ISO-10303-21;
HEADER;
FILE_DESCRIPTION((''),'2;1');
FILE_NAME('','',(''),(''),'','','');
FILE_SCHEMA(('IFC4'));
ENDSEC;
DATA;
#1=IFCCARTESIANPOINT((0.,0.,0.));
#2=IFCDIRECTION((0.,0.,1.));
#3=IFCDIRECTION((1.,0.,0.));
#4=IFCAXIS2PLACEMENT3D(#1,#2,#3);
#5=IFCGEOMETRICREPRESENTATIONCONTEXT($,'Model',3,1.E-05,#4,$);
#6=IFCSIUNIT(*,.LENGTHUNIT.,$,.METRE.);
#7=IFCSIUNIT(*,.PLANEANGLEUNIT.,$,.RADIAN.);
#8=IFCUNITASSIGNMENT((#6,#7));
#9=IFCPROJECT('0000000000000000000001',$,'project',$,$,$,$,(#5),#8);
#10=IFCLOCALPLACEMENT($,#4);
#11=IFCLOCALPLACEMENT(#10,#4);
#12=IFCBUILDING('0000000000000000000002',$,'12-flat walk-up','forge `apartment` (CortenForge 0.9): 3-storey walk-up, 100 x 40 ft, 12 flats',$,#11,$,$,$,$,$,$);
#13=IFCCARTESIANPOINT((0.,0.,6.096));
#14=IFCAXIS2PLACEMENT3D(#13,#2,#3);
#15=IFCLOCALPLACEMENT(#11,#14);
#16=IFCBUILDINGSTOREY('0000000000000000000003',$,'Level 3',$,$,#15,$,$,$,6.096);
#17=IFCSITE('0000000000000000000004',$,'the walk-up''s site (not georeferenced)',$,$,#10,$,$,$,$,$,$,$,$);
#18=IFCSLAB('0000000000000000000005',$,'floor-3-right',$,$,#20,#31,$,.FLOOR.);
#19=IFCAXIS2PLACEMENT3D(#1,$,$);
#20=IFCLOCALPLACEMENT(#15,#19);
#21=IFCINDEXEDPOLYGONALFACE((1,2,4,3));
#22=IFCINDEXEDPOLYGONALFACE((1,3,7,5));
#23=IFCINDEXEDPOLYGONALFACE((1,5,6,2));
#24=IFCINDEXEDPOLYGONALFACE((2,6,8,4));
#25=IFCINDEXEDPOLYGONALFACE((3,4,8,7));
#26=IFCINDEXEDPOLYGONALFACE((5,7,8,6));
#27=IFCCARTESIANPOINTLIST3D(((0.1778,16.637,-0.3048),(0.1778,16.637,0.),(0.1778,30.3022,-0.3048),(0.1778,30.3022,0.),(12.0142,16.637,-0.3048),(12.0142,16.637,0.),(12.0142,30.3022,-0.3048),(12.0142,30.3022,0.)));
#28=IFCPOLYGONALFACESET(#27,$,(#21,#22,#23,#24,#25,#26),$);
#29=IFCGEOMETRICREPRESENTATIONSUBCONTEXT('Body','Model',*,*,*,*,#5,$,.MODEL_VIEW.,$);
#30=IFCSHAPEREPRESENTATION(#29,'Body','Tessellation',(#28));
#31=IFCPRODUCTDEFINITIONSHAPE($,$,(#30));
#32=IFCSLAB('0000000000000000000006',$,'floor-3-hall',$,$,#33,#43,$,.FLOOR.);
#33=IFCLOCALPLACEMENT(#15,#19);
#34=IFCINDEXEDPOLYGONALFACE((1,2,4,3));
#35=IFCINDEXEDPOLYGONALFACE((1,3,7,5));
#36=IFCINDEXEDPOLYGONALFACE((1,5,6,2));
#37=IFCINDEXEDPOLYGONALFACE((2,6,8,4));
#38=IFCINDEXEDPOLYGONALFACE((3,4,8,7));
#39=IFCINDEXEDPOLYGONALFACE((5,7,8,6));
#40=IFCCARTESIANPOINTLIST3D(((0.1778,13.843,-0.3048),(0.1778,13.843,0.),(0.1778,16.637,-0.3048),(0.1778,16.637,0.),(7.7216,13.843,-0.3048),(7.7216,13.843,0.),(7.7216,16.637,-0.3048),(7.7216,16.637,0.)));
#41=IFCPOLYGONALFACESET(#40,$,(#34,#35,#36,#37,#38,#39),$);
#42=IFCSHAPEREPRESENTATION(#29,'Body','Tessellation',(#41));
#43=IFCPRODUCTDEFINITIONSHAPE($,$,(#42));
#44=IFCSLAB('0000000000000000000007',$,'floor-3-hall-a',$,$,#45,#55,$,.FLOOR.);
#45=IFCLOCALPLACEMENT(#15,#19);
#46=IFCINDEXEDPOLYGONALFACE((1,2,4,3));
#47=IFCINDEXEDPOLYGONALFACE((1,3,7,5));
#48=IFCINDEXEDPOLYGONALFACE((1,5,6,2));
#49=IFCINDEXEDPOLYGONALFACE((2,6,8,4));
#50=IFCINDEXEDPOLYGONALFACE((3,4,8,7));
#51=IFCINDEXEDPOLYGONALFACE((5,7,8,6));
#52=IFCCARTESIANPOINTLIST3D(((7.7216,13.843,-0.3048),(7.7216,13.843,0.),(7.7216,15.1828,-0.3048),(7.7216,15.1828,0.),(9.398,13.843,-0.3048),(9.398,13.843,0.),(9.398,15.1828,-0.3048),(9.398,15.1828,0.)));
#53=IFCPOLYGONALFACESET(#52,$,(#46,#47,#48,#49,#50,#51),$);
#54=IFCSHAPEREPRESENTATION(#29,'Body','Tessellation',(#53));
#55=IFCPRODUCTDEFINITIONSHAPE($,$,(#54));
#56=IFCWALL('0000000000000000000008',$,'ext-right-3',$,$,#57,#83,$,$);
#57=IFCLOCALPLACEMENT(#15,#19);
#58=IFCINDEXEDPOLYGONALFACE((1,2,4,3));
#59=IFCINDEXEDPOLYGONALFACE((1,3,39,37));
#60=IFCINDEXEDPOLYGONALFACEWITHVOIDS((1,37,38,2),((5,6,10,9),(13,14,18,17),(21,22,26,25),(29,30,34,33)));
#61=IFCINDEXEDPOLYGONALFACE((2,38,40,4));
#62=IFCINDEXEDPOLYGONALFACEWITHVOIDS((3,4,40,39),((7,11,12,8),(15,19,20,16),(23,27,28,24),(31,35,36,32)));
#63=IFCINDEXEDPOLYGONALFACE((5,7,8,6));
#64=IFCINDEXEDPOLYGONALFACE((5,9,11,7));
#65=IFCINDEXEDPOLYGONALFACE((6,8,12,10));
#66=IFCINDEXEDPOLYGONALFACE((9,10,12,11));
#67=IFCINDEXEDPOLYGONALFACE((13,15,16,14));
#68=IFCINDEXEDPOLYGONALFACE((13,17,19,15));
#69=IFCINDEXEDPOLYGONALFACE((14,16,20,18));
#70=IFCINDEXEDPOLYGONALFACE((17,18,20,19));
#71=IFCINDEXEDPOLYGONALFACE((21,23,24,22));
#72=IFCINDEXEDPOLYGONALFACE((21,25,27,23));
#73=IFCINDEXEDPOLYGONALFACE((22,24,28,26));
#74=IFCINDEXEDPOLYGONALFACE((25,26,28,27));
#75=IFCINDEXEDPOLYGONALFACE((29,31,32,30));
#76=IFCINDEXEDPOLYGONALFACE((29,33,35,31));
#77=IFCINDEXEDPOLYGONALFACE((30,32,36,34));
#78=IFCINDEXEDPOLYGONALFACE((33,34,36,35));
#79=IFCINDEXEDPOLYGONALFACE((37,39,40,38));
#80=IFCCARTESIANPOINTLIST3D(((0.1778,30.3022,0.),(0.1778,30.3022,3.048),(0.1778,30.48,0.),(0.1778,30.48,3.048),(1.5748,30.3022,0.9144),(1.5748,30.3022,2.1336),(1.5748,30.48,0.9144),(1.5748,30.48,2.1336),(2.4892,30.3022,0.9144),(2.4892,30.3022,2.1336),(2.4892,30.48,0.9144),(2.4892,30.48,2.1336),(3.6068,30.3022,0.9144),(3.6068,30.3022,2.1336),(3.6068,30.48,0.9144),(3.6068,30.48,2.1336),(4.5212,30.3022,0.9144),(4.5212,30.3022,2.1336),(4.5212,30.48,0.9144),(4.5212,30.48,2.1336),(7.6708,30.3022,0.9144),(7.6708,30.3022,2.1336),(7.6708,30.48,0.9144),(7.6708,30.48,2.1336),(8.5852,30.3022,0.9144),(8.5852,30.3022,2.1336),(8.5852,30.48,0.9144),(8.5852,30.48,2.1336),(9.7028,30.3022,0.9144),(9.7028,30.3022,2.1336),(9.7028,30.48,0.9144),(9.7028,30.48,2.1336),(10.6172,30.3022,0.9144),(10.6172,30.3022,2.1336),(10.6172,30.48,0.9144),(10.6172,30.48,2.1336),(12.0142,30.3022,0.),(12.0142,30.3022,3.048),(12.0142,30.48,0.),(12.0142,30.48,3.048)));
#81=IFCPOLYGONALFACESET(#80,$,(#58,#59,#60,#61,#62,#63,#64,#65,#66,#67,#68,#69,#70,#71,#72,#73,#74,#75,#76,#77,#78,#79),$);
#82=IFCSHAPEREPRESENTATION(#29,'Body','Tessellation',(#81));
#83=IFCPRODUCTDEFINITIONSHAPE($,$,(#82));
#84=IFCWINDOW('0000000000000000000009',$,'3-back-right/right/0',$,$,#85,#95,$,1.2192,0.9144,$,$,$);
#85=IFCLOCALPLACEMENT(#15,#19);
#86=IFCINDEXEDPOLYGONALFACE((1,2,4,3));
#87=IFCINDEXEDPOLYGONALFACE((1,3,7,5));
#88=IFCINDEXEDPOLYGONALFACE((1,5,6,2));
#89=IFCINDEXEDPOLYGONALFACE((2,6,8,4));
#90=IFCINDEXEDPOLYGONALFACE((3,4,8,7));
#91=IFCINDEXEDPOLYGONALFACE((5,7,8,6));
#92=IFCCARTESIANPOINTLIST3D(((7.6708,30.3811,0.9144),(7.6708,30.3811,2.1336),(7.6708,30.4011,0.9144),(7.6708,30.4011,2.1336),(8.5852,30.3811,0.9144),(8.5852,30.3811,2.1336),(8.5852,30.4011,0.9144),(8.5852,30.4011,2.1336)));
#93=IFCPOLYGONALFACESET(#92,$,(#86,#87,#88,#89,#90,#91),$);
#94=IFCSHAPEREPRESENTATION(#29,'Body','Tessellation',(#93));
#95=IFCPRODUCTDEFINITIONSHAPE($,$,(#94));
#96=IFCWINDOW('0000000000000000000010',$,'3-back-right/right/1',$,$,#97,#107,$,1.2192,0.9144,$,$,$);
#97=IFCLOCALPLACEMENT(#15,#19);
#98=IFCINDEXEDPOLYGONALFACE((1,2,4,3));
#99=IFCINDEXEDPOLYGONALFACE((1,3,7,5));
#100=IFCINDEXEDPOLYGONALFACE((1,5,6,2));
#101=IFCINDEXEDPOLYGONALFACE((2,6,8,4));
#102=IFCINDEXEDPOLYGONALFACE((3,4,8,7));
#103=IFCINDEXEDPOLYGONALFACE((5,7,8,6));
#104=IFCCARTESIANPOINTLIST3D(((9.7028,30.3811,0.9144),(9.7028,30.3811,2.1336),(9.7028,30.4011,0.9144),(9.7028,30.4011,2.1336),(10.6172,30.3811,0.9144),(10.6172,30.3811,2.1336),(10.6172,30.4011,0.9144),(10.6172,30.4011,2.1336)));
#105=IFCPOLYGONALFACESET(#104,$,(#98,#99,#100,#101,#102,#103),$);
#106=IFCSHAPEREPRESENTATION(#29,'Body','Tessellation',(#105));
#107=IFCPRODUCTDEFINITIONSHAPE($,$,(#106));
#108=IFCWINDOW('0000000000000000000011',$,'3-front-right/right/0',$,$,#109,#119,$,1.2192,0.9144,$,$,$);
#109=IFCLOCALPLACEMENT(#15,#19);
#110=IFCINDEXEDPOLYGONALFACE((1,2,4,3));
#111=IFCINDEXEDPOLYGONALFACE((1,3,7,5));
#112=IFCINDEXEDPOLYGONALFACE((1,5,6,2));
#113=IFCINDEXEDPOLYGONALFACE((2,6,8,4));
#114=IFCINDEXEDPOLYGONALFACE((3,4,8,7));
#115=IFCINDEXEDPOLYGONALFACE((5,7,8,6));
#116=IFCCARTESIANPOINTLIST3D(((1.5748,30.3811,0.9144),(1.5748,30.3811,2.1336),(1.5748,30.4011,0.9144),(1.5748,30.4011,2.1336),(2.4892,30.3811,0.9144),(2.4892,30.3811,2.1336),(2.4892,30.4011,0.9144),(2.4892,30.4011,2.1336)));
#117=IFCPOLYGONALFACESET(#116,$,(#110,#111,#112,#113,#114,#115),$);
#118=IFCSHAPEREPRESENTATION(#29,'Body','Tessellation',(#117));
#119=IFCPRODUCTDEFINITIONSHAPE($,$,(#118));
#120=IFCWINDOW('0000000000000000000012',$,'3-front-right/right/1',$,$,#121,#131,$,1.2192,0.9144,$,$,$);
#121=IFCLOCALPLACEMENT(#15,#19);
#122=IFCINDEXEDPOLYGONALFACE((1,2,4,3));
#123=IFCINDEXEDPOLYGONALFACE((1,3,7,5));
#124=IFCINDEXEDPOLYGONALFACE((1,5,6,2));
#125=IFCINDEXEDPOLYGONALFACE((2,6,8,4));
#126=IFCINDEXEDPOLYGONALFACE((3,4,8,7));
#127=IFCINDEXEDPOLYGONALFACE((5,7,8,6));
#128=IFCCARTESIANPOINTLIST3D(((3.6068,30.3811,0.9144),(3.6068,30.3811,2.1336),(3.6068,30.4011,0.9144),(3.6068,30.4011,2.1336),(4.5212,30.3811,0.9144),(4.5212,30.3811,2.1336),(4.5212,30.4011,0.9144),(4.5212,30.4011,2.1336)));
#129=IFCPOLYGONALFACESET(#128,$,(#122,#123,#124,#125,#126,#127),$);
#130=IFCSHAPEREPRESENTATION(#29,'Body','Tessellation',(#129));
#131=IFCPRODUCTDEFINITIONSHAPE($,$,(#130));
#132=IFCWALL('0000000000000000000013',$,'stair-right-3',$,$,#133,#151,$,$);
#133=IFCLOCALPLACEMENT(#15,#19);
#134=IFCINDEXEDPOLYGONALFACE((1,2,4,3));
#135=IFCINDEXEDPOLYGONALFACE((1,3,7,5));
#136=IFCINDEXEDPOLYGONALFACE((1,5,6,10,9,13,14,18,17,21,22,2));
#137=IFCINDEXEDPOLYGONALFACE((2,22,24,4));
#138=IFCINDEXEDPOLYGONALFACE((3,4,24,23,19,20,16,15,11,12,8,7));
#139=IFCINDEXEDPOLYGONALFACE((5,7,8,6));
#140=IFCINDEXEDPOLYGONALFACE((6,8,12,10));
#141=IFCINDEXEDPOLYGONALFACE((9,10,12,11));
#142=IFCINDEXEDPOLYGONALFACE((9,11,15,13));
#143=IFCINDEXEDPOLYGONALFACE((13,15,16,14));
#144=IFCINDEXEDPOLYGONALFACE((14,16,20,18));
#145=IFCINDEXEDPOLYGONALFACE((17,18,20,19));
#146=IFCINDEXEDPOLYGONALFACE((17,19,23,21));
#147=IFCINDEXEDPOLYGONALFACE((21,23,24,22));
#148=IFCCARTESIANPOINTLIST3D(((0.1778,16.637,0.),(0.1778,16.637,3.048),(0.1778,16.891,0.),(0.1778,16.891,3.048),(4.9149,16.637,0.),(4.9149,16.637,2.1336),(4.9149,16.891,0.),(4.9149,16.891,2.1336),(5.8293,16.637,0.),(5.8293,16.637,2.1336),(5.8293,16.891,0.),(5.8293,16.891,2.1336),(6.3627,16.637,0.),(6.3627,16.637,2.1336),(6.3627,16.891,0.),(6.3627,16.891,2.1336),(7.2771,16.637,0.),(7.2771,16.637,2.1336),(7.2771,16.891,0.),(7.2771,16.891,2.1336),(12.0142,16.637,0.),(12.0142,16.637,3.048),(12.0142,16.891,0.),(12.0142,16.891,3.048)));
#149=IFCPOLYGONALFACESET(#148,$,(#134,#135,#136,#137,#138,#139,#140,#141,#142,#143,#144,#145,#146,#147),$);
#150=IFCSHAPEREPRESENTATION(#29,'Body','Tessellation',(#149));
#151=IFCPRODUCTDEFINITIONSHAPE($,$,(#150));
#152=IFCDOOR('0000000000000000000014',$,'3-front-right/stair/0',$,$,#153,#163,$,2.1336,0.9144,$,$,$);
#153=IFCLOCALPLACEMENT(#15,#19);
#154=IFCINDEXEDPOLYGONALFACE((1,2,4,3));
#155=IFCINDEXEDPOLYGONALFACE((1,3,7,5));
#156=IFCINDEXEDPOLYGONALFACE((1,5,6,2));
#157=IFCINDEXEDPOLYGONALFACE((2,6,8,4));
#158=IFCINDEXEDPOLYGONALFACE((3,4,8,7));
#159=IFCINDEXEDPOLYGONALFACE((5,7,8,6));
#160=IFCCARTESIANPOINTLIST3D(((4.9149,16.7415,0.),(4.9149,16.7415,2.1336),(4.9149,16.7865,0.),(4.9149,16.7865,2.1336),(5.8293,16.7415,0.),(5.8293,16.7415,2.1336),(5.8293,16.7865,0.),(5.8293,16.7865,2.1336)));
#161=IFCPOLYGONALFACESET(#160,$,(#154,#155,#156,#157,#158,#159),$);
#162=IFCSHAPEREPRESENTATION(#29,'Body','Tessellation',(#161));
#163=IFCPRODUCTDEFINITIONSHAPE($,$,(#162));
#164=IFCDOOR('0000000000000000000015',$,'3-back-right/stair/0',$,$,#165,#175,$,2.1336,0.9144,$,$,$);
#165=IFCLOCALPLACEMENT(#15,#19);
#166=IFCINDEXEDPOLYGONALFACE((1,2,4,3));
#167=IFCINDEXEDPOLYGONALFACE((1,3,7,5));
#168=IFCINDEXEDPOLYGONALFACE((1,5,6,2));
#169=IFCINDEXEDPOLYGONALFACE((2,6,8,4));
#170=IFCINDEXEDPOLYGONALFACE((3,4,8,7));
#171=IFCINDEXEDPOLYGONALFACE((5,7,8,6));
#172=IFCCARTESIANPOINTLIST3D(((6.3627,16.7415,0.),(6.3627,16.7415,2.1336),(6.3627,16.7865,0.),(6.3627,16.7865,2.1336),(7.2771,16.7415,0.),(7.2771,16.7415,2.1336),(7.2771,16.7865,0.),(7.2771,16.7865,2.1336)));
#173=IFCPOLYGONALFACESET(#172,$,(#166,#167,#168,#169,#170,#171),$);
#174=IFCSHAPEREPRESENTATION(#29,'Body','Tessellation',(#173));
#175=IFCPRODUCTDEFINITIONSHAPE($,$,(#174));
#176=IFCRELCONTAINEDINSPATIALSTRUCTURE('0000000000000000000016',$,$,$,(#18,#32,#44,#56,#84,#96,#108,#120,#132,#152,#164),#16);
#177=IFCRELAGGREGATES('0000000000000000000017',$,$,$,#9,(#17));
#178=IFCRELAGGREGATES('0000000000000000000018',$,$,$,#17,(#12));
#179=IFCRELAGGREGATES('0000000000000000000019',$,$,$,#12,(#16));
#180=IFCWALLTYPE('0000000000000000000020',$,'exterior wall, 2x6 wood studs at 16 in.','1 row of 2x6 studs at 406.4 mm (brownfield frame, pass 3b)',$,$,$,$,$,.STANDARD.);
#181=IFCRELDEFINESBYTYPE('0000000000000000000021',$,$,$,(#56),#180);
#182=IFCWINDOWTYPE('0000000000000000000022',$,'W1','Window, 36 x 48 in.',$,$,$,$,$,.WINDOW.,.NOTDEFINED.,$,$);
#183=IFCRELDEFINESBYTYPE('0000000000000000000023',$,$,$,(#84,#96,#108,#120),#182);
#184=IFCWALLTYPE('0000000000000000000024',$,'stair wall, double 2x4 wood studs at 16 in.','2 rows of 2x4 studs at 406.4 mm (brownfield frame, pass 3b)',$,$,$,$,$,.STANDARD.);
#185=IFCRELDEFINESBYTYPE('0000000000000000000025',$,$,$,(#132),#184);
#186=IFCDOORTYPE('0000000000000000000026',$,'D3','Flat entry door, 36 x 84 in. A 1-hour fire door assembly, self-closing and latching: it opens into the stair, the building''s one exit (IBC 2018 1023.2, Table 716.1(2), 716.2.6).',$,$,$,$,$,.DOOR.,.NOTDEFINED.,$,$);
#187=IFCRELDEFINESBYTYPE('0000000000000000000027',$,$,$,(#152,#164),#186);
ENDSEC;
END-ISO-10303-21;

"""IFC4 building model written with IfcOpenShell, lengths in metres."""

from ifc_helpers import new_model, si_unit, frame, frame_2d, origin, origin_with_axes, place, context, subcontext, project, spatial, rectangle, extrude, type_object, element, fill, save


model = new_model("IFC4")

# Units and contexts
model_context = context("Model", 3, precision=1e-05, world=origin_with_axes())
body_context = subcontext(model_context, "Body", "Model", "MODEL_VIEW")
ifc_project = project(units=[si_unit("LENGTHUNIT", "METRE"), si_unit("PLANEANGLEUNIT", "RADIAN")], contexts=[model_context])

# Site, building, storey
site_placement = place(None, origin_with_axes())
site = spatial("IfcSite", under=ifc_project, at=site_placement, Name="the walk-up's site (not georeferenced)")
building_placement = place(site_placement, origin_with_axes())
building = spatial("IfcBuilding", under=site, at=building_placement, Name="12-flat walk-up", Description="forge `apartment` (CortenForge 0.9): 3-storey walk-up, 100 x 40 ft, 12 flats")
storey_placement = place(building_placement, frame((0.0, 0.0, 6.096), z_axis=(0.0, 0.0, 1.0), x_axis=(1.0, 0.0, 0.0)))
storey = spatial("IfcBuildingStorey", under=building, at=storey_placement, Name="Level 3", Elevation=6.096)

# Slabs
slab_1_placement = place(storey_placement, frame((0.1778, 16.637, -0.3048), z_axis=(0.0, 0.0, 1.0), x_axis=(1.0, 0.0, 0.0)))
element("IfcSlab", 1, at=slab_1_placement, inside=storey, Name="floor-3-right", PredefinedType="FLOOR", context=body_context, shape_type="SweptSolid", body=[
    extrude(rectangle(XDim=11.8364, YDim=13.6652, at=frame_2d((5.9182, 6.8326))), origin(), (0.0, 0.0, 1.0), 0.3048),
])
slab_2_placement = place(storey_placement, frame((0.1778, 13.843, -0.3048), z_axis=(0.0, 0.0, 1.0), x_axis=(1.0, 0.0, 0.0)))
element("IfcSlab", 2, at=slab_2_placement, inside=storey, Name="floor-3-hall", PredefinedType="FLOOR", context=body_context, shape_type="SweptSolid", body=[
    extrude(rectangle(XDim=7.5438, YDim=2.794, at=frame_2d((3.7719, 1.397))), origin(), (0.0, 0.0, 1.0), 0.3048),
])
slab_3_placement = place(storey_placement, frame((7.7216, 13.843, -0.3048), z_axis=(0.0, 0.0, 1.0), x_axis=(1.0, 0.0, 0.0)))
element("IfcSlab", 3, at=slab_3_placement, inside=storey, Name="floor-3-hall-a", PredefinedType="FLOOR", context=body_context, shape_type="SweptSolid", body=[
    extrude(rectangle(XDim=1.6764, YDim=1.3399, at=frame_2d((0.8382, 0.6699))), origin(), (0.0, 0.0, 1.0), 0.3048),
])

# Wall, openings, windows
wall_type_1 = type_object("IfcWallType", Name="exterior wall, 2x6 wood studs at 16 in.", Description="1 row of 2x6 studs at 406.4 mm (brownfield frame, pass 3b)", PredefinedType="STANDARD")
wall_1_placement = place(storey_placement, frame((0.1778, 30.3022, 0.0), z_axis=(0.0, 0.0, 1.0), x_axis=(1.0, 0.0, 0.0)))
wall_1 = element("IfcWall", 4, at=wall_1_placement, inside=storey, type_object=wall_type_1, Name="ext-right-3", context=body_context, shape_type="SweptSolid", body=[
    extrude(rectangle(XDim=11.8364, YDim=0.1778, at=frame_2d((5.9182, 0.0889))), origin(), (0.0, 0.0, 1.0), 3.048),
])
opening_1_placement = place(wall_1_placement, frame((8.4074, 0.1778, 0.9144), z_axis=(0.0, 0.0, 1.0), x_axis=(-1.0, 0.0, 0.0)))
opening_1 = element("IfcOpeningElement", 5, at=opening_1_placement, cuts=wall_1, PredefinedType="OPENING", context=body_context, shape_type="SweptSolid", body=[
    extrude(rectangle(XDim=0.9144, YDim=0.1778, at=frame_2d((0.4572, 0.0889))), origin(), (0.0, 0.0, 1.0), 1.2192),
])
opening_2_placement = place(wall_1_placement, frame((10.4394, 0.1778, 0.9144), z_axis=(0.0, 0.0, 1.0), x_axis=(-1.0, 0.0, 0.0)))
opening_2 = element("IfcOpeningElement", 6, at=opening_2_placement, cuts=wall_1, PredefinedType="OPENING", context=body_context, shape_type="SweptSolid", body=[
    extrude(rectangle(XDim=0.9144, YDim=0.1778, at=frame_2d((0.4572, 0.0889))), origin(), (0.0, 0.0, 1.0), 1.2192),
])
opening_3_placement = place(wall_1_placement, frame((2.3114, 0.1778, 0.9144), z_axis=(0.0, 0.0, 1.0), x_axis=(-1.0, 0.0, 0.0)))
opening_3 = element("IfcOpeningElement", 7, at=opening_3_placement, cuts=wall_1, PredefinedType="OPENING", context=body_context, shape_type="SweptSolid", body=[
    extrude(rectangle(XDim=0.9144, YDim=0.1778, at=frame_2d((0.4572, 0.0889))), origin(), (0.0, 0.0, 1.0), 1.2192),
])
opening_4_placement = place(wall_1_placement, frame((4.3434, 0.1778, 0.9144), z_axis=(0.0, 0.0, 1.0), x_axis=(-1.0, 0.0, 0.0)))
opening_4 = element("IfcOpeningElement", 8, at=opening_4_placement, cuts=wall_1, PredefinedType="OPENING", context=body_context, shape_type="SweptSolid", body=[
    extrude(rectangle(XDim=0.9144, YDim=0.1778, at=frame_2d((0.4572, 0.0889))), origin(), (0.0, 0.0, 1.0), 1.2192),
])
window_type = type_object("IfcWindowType", Name="W1", Description="Window, 36 x 48 in.", PartitioningType="NOTDEFINED", PredefinedType="WINDOW")
window_1_placement = place(opening_1_placement, frame((0.0, 0.0789, 0.0), z_axis=(0.0, 0.0, 1.0), x_axis=(1.0, 0.0, 0.0)))
window_1 = element("IfcWindow", 9, at=window_1_placement, inside=storey, type_object=window_type, Name="3-back-right/right/0", OverallHeight=1.2192, OverallWidth=0.9144, context=body_context, shape_type="SweptSolid", body=[
    extrude(rectangle(XDim=0.9144, YDim=0.02, at=frame_2d((0.4572, 0.01))), origin(), (0.0, 0.0, 1.0), 1.2192),
])
fill(opening_1, window_1)
window_2_placement = place(opening_2_placement, frame((0.0, 0.0789, 0.0), z_axis=(0.0, 0.0, 1.0), x_axis=(1.0, 0.0, 0.0)))
window_2 = element("IfcWindow", 10, at=window_2_placement, inside=storey, type_object=window_type, Name="3-back-right/right/1", OverallHeight=1.2192, OverallWidth=0.9144, context=body_context, shape_type="SweptSolid", body=[
    extrude(rectangle(XDim=0.9144, YDim=0.02, at=frame_2d((0.4572, 0.01))), origin(), (0.0, 0.0, 1.0), 1.2192),
])
fill(opening_2, window_2)
window_3_placement = place(opening_3_placement, frame((0.0, 0.0789, 0.0), z_axis=(0.0, 0.0, 1.0), x_axis=(1.0, 0.0, 0.0)))
window_3 = element("IfcWindow", 11, at=window_3_placement, inside=storey, type_object=window_type, Name="3-front-right/right/0", OverallHeight=1.2192, OverallWidth=0.9144, context=body_context, shape_type="SweptSolid", body=[
    extrude(rectangle(XDim=0.9144, YDim=0.02, at=frame_2d((0.4572, 0.01))), origin(), (0.0, 0.0, 1.0), 1.2192),
])
fill(opening_3, window_3)
window_4_placement = place(opening_4_placement, frame((0.0, 0.0789, 0.0), z_axis=(0.0, 0.0, 1.0), x_axis=(1.0, 0.0, 0.0)))
window_4 = element("IfcWindow", 12, at=window_4_placement, inside=storey, type_object=window_type, Name="3-front-right/right/1", OverallHeight=1.2192, OverallWidth=0.9144, context=body_context, shape_type="SweptSolid", body=[
    extrude(rectangle(XDim=0.9144, YDim=0.02, at=frame_2d((0.4572, 0.01))), origin(), (0.0, 0.0, 1.0), 1.2192),
])
fill(opening_4, window_4)

# Wall, openings, doors
wall_type_2 = type_object("IfcWallType", Name="stair wall, double 2x4 wood studs at 16 in.", Description="2 rows of 2x4 studs at 406.4 mm (brownfield frame, pass 3b)", PredefinedType="STANDARD")
wall_2_placement = place(storey_placement, frame((0.1778, 16.637, 0.0), z_axis=(0.0, 0.0, 1.0), x_axis=(1.0, 0.0, 0.0)))
wall_2 = element("IfcWall", 13, at=wall_2_placement, inside=storey, type_object=wall_type_2, Name="stair-right-3", context=body_context, shape_type="SweptSolid", body=[
    extrude(rectangle(XDim=11.8364, YDim=0.254, at=frame_2d((5.9182, 0.127))), origin(), (0.0, 0.0, 1.0), 3.048),
])
opening_5_placement = place(wall_2_placement, frame((5.6515, 0.254, 0.0), z_axis=(0.0, 0.0, 1.0), x_axis=(-1.0, 0.0, 0.0)))
opening_5 = element("IfcOpeningElement", 14, at=opening_5_placement, cuts=wall_2, PredefinedType="OPENING", context=body_context, shape_type="SweptSolid", body=[
    extrude(rectangle(XDim=0.9144, YDim=0.254, at=frame_2d((0.4572, 0.127))), origin(), (0.0, 0.0, 1.0), 2.1336),
])
opening_6_placement = place(wall_2_placement, frame((7.0993, 0.254, 0.0), z_axis=(0.0, 0.0, 1.0), x_axis=(-1.0, 0.0, 0.0)))
opening_6 = element("IfcOpeningElement", 15, at=opening_6_placement, cuts=wall_2, PredefinedType="OPENING", context=body_context, shape_type="SweptSolid", body=[
    extrude(rectangle(XDim=0.9144, YDim=0.254, at=frame_2d((0.4572, 0.127))), origin(), (0.0, 0.0, 1.0), 2.1336),
])
door_type = type_object("IfcDoorType", Name="D3", Description="Flat entry door, 36 x 84 in. A 1-hour fire door assembly, self-closing and latching: it opens into the stair, the building's one exit (IBC 2018 1023.2, Table 716.1(2), 716.2.6).", OperationType="NOTDEFINED", PredefinedType="DOOR")
door_1_placement = place(opening_5_placement, frame((0.0, 0.1045, 0.0), z_axis=(0.0, 0.0, 1.0), x_axis=(1.0, 0.0, 0.0)))
door_1 = element("IfcDoor", 16, at=door_1_placement, inside=storey, type_object=door_type, Name="3-front-right/stair/0", OverallHeight=2.1336, OverallWidth=0.9144, context=body_context, shape_type="SweptSolid", body=[
    extrude(rectangle(XDim=0.9144, YDim=0.045, at=frame_2d((0.4572, 0.0225))), origin(), (0.0, 0.0, 1.0), 2.1336),
])
fill(opening_5, door_1)
door_2_placement = place(opening_6_placement, frame((0.0, 0.1045, 0.0), z_axis=(0.0, 0.0, 1.0), x_axis=(1.0, 0.0, 0.0)))
door_2 = element("IfcDoor", 17, at=door_2_placement, inside=storey, type_object=door_type, Name="3-back-right/stair/0", OverallHeight=2.1336, OverallWidth=0.9144, context=body_context, shape_type="SweptSolid", body=[
    extrude(rectangle(XDim=0.9144, YDim=0.045, at=frame_2d((0.4572, 0.0225))), origin(), (0.0, 0.0, 1.0), 2.1336),
])
fill(opening_6, door_2)

save(model, "model.ifc")
